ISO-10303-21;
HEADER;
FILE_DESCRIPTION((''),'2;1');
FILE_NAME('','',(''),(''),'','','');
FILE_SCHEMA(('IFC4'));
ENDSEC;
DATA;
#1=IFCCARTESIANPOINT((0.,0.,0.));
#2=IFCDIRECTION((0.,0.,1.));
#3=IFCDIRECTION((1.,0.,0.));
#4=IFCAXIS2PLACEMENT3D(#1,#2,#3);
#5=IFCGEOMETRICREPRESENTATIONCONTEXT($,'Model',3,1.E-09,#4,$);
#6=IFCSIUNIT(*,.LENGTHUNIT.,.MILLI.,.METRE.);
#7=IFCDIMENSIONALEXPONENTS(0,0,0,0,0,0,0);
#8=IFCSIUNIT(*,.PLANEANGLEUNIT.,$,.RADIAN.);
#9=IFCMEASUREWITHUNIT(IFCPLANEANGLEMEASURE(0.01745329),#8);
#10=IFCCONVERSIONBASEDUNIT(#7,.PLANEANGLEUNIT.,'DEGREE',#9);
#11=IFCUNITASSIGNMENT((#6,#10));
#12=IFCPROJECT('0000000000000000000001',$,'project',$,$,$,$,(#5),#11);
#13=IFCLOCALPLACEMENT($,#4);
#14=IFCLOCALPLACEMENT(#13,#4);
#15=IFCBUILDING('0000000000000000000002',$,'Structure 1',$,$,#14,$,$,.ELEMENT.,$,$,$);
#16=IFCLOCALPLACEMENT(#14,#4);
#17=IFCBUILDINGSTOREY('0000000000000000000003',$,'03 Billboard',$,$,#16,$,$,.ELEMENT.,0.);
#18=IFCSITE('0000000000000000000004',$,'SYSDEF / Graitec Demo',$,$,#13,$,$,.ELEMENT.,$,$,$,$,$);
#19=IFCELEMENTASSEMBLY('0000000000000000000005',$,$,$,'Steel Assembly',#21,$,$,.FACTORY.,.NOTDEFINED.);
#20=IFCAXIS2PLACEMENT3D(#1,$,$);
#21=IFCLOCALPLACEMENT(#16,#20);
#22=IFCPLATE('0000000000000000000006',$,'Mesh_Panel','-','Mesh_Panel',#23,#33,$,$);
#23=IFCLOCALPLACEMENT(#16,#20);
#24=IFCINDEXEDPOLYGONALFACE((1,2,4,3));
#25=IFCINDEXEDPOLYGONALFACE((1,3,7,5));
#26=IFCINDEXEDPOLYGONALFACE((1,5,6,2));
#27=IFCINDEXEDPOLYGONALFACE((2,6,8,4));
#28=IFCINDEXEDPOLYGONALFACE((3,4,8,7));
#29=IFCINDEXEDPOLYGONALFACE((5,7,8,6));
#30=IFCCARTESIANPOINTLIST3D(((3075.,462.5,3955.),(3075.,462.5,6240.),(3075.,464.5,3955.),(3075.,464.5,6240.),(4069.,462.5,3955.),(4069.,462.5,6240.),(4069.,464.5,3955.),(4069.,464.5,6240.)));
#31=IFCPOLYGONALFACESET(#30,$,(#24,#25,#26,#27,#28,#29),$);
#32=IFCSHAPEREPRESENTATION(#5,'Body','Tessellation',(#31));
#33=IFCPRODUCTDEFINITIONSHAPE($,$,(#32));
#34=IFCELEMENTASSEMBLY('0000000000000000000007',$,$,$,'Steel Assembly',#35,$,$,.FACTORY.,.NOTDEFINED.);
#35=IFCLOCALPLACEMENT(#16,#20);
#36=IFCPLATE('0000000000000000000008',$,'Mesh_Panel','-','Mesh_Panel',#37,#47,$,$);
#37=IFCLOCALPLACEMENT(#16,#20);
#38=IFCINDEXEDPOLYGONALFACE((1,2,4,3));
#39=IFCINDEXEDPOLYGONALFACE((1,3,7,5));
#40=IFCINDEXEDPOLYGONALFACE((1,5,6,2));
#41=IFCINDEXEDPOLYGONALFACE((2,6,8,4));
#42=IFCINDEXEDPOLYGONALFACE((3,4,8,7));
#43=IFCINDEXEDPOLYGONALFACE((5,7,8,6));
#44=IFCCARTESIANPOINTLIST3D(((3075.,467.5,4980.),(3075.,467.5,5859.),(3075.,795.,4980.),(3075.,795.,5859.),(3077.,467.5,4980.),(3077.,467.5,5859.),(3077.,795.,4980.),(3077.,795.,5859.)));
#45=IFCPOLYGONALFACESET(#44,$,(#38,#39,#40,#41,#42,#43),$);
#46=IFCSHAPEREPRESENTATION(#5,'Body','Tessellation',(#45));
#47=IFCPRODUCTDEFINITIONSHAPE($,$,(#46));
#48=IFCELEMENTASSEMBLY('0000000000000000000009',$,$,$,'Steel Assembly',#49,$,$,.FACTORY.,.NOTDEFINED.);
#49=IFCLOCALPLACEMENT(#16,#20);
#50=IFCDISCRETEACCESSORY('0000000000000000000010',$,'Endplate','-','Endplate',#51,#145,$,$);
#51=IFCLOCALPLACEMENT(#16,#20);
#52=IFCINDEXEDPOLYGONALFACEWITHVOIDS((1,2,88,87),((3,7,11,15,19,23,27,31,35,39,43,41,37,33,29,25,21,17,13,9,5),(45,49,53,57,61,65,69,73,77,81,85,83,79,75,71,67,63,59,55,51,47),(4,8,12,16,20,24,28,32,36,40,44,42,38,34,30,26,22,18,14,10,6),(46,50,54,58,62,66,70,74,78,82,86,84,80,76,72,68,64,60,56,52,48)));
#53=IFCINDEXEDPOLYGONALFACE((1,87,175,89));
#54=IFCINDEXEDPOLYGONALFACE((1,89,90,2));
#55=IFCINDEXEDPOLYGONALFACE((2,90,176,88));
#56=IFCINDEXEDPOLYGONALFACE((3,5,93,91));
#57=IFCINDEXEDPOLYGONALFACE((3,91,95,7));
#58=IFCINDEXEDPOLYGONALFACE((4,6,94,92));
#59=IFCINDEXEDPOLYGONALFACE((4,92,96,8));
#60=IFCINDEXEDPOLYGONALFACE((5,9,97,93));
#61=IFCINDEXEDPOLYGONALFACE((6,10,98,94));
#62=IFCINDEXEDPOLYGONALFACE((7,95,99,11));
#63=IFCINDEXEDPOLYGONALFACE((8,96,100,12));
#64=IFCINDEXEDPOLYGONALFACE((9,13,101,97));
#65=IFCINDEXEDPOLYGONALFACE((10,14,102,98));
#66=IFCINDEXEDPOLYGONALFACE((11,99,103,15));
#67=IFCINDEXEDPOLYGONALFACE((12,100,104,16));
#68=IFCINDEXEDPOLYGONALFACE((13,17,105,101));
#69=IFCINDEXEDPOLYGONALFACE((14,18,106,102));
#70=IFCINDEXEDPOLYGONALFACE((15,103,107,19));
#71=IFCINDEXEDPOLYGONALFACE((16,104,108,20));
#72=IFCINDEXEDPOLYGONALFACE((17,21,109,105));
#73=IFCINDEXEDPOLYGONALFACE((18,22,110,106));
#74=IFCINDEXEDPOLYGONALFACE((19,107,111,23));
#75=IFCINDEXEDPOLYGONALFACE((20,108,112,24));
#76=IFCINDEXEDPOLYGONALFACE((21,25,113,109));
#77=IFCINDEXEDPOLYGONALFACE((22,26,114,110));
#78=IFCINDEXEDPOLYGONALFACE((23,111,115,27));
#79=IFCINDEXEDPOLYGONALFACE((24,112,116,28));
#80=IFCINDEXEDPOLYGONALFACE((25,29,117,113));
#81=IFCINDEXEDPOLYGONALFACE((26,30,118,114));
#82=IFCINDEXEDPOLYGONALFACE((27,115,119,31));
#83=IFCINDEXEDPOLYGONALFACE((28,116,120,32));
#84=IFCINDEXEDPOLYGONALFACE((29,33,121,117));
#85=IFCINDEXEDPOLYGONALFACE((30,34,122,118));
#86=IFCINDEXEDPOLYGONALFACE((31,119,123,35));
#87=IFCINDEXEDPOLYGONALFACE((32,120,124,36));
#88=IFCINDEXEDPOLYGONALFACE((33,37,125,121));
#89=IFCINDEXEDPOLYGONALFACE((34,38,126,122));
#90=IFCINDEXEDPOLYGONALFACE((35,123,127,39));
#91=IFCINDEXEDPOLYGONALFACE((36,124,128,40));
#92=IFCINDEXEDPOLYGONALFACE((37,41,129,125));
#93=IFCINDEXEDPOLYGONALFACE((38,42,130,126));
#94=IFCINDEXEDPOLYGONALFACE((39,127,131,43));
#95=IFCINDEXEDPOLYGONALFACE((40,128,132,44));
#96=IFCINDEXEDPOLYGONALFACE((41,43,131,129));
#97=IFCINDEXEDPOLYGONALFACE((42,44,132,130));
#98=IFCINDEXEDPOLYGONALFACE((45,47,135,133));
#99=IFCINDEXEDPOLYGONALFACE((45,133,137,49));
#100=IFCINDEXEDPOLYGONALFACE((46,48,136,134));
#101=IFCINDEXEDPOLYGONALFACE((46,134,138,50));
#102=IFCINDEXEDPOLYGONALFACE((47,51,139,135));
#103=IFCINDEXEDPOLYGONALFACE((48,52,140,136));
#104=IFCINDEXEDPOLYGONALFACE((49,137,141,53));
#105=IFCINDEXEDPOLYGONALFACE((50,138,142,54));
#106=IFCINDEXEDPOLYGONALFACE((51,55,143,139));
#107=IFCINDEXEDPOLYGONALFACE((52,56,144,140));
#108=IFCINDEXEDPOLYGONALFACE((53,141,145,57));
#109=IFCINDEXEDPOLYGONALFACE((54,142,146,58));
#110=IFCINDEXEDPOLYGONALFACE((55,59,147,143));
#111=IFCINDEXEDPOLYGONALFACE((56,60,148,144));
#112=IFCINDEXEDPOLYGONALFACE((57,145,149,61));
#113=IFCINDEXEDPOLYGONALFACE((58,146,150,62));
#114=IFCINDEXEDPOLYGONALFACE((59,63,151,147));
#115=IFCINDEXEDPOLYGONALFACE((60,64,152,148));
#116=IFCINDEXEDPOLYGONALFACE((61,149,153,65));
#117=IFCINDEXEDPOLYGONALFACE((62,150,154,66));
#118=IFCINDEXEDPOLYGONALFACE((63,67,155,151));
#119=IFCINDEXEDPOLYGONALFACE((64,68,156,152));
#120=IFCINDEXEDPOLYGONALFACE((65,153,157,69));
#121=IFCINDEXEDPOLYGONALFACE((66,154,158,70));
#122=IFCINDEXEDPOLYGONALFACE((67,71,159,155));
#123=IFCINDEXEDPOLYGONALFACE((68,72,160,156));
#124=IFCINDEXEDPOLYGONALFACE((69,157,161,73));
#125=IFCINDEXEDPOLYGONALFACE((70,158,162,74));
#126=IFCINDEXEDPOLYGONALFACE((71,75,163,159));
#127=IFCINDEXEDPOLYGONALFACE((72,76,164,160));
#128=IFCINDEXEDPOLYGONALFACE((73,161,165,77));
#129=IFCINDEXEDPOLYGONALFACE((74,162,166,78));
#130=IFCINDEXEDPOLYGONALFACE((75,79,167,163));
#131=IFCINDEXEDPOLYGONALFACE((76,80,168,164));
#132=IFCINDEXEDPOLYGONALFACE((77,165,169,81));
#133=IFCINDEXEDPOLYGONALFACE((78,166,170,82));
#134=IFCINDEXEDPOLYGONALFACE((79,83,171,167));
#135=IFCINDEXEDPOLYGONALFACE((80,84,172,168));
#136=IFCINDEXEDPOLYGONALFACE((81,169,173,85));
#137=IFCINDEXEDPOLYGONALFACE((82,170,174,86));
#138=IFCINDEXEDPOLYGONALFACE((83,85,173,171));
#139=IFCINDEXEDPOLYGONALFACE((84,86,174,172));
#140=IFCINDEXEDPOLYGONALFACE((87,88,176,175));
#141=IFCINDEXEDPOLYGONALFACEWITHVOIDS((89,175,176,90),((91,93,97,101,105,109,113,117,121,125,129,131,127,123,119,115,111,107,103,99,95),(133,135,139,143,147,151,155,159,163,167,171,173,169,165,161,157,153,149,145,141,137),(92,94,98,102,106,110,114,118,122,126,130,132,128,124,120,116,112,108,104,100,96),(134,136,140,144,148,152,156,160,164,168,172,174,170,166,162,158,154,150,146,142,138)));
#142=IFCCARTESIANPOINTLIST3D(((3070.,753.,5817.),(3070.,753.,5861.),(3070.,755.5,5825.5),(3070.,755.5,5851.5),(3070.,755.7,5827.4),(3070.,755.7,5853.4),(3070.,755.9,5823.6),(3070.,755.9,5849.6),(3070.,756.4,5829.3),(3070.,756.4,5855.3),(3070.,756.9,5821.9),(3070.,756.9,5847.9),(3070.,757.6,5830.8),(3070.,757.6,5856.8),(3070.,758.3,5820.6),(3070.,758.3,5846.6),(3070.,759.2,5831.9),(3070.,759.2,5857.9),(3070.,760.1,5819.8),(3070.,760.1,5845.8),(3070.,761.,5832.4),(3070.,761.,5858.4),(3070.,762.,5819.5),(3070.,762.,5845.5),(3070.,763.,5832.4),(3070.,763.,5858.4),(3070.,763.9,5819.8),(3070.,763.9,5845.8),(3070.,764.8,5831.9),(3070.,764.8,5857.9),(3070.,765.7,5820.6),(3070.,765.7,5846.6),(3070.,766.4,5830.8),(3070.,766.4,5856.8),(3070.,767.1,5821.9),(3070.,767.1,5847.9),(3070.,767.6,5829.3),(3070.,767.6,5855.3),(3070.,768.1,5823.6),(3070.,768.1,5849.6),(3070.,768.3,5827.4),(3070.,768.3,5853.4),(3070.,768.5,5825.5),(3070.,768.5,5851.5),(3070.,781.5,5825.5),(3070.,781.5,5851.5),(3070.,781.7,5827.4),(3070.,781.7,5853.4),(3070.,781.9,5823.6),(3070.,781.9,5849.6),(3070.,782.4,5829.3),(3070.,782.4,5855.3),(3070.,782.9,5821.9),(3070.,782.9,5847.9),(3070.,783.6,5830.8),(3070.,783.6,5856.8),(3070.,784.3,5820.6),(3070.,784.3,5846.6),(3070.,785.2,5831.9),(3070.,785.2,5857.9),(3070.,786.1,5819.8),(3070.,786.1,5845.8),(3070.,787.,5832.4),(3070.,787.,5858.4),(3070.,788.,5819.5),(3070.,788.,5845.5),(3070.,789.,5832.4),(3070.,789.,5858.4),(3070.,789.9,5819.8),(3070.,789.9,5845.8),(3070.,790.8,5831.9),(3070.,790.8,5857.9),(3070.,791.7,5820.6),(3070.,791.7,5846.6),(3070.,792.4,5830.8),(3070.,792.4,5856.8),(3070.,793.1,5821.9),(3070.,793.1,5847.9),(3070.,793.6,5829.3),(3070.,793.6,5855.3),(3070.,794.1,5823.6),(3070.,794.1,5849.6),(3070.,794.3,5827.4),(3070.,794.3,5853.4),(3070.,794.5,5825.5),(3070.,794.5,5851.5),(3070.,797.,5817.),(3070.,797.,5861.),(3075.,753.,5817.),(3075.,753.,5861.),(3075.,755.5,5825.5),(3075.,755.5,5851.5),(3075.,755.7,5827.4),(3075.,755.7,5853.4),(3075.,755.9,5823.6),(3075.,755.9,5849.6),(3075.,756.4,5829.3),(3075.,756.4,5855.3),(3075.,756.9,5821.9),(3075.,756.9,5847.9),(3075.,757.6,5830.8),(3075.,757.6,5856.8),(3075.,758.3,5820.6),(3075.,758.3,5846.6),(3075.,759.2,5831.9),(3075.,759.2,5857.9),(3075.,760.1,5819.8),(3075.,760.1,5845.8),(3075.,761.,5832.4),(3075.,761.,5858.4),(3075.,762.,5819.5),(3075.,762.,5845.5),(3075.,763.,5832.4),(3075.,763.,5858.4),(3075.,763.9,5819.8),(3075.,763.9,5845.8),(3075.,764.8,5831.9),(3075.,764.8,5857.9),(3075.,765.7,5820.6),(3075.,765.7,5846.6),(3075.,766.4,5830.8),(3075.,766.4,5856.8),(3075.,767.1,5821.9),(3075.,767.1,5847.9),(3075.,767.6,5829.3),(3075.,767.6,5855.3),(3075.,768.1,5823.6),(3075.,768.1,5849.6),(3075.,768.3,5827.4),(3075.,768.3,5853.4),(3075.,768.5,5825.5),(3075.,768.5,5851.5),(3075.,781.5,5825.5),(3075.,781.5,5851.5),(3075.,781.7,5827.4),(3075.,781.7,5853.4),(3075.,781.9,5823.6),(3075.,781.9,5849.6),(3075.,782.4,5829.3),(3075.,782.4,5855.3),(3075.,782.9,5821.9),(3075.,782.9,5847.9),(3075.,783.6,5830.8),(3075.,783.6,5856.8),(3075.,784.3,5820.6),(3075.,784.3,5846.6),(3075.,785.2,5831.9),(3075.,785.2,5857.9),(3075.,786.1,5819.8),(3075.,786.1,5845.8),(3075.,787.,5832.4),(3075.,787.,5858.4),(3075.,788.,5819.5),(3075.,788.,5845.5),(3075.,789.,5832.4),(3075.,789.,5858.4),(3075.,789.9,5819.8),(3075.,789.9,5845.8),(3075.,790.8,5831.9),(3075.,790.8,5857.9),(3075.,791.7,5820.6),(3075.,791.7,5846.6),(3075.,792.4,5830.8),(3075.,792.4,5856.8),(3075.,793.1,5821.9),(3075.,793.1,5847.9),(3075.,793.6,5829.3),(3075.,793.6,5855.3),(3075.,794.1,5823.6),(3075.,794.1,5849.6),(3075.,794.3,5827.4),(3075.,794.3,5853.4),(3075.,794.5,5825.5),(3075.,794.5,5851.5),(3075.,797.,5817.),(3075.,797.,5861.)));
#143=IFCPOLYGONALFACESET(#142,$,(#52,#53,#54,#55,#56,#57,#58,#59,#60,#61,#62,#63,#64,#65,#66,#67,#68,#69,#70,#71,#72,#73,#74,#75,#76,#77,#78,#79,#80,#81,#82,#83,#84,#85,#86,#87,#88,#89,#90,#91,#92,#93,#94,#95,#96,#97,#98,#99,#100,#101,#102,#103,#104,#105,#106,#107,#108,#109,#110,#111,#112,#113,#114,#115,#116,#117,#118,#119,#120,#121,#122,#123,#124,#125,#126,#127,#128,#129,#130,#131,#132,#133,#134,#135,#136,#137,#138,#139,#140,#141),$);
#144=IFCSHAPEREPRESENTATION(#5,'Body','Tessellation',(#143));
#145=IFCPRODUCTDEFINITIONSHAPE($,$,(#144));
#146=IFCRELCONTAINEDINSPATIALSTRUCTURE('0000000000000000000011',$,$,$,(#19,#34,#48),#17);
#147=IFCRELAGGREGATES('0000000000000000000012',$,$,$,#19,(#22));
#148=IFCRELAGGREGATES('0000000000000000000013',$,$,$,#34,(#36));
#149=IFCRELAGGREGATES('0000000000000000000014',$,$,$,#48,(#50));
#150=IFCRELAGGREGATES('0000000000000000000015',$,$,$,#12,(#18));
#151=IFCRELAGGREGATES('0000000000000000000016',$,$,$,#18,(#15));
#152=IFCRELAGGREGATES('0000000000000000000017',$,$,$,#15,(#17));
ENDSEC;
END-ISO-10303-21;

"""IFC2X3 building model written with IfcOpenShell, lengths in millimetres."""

from ifc_helpers import new_model, entity, si_unit, converted_unit, frame, frame_2d, origin, origin_with_axes, place, context, project, spatial, polyline, circle, outline, extrude, element, aggregate, save


model = new_model("IFC2X3")

# Units and contexts
model_context = context("Model", 3, precision=1e-09, world=origin_with_axes())
ifc_project = project(units=[si_unit("LENGTHUNIT", "METRE", prefix="MILLI"), converted_unit("PLANEANGLEUNIT", "DEGREE", entity("IfcPlaneAngleMeasure", 0.01745329), si_unit("PLANEANGLEUNIT", "RADIAN"), dimensions=[0, 0, 0, 0, 0, 0, 0])], contexts=[model_context])

# Site, building, storey
site_placement = place(None, origin_with_axes())
site = spatial("IfcSite", under=ifc_project, at=site_placement, Name="SYSDEF / Graitec Demo", CompositionType="ELEMENT")
building_placement = place(site_placement, origin_with_axes())
building = spatial("IfcBuilding", under=site, at=building_placement, Name="Structure 1", CompositionType="ELEMENT")
storey_placement = place(building_placement, origin_with_axes())
storey = spatial("IfcBuildingStorey", under=building, at=storey_placement, Name="03 Billboard", CompositionType="ELEMENT", Elevation=0.0)

# Element assemblies, plates
assembly_1_placement = place(None, frame((3572.0, 464.5, 5097.5), z_axis=(0.0, -1.0, 0.0), x_axis=(-1.0, 0.0, 0.0)))
assembly_1 = element("IfcElementAssembly", 1, at=assembly_1_placement, inside=storey, ObjectType="Steel Assembly", AssemblyPlace="FACTORY", PredefinedType="NOTDEFINED")
plate_1_placement = place(assembly_1_placement, origin_with_axes())
plate_1 = element("IfcPlate", 2, at=plate_1_placement, Name="Mesh_Panel", Description="-", ObjectType="Mesh_Panel", context=model_context, shape_type="SweptSolid", body=[
    extrude(outline(polyline([(-497.0, -1142.5), (497.0, -1142.5), (497.0, 1142.5), (-497.0, 1142.5), (-497.0, -1142.5)])), origin_with_axes(), (0.0, 0.0, 1.0), 2.0),
])
aggregate(assembly_1, [plate_1])
assembly_2_placement = place(None, frame((3077.0, 631.3, 5419.5), z_axis=(-1.0, 0.0, 0.0), x_axis=(0.0, 1.0, 0.0)))
assembly_2 = element("IfcElementAssembly", 3, at=assembly_2_placement, inside=storey, ObjectType="Steel Assembly", AssemblyPlace="FACTORY", PredefinedType="NOTDEFINED")
plate_2_placement = place(assembly_2_placement, origin_with_axes())
plate_2 = element("IfcPlate", 4, at=plate_2_placement, Name="Mesh_Panel", Description="-", ObjectType="Mesh_Panel", context=model_context, shape_type="SweptSolid", body=[
    extrude(outline(polyline([(-163.7, -439.5), (163.7, -439.5), (163.7, 439.5), (-163.7, 439.5), (-163.7, -439.5)])), origin_with_axes(), (0.0, 0.0, 1.0), 2.0),
])
aggregate(assembly_2, [plate_2])

# Element assembly, discrete accessory, openings
assembly_3_placement = place(None, frame((-4239.1, -387.5, 4000.0), z_axis=(-1.0, 0.0, 0.0), x_axis=(0.0, 0.0, 1.0)))
assembly_3 = element("IfcElementAssembly", 5, at=assembly_3_placement, inside=storey, ObjectType="Steel Assembly", AssemblyPlace="FACTORY", PredefinedType="NOTDEFINED")
discrete_accessory_1_placement = place(assembly_3_placement, frame((1861.0, 1184.5, -7309.1), z_axis=(0.0, 0.0, -1.0), x_axis=(0.0, -1.0, 0.0)))
discrete_accessory_1 = element("IfcDiscreteAccessory", 6, at=discrete_accessory_1_placement, Name="Endplate", Description="-", ObjectType="Endplate", context=model_context, shape_type="SweptSolid", body=[
    extrude(outline(polyline([(0.0, 0.0), (44.0, 0.0), (44.0, 44.0), (0.0, 44.0), (0.0, 0.0)])), origin_with_axes(), (0.0, 0.0, 1.0), 5.0),
])
opening_1_placement = place(discrete_accessory_1_placement, frame((22.0, 22.0, 5.5), z_axis=(0.0, 0.0, -1.0), x_axis=(0.0, 1.0, 0.0)))
element("IfcOpeningElement", 7, at=opening_1_placement, cuts=discrete_accessory_1, ObjectType="Opening", context=model_context, shape_type="SweptSolid", body=[
    extrude(circle(Radius=6.5, at=frame_2d((13.0, 13.0), x_axis=(1.0, 0.0))), origin(), (0.0, 0.0, 1.0), 6.0),
])
opening_2_placement = place(discrete_accessory_1_placement, frame((22.0, 22.0, 5.5), z_axis=(0.0, 0.0, -1.0), x_axis=(0.0, 1.0, 0.0)))
element("IfcOpeningElement", 8, at=opening_2_placement, cuts=discrete_accessory_1, ObjectType="Opening", context=model_context, shape_type="SweptSolid", body=[
    extrude(circle(Radius=6.5, at=frame_2d((-13.0, 13.0), x_axis=(1.0, 0.0))), origin(), (0.0, 0.0, 1.0), 6.0),
])
opening_3_placement = place(discrete_accessory_1_placement, frame((22.0, 22.0, 5.5), z_axis=(0.0, 0.0, -1.0), x_axis=(0.0, 1.0, 0.0)))
element("IfcOpeningElement", 9, at=opening_3_placement, cuts=discrete_accessory_1, ObjectType="Opening", context=model_context, shape_type="SweptSolid", body=[
    extrude(circle(Radius=6.5, at=frame_2d((13.0, -13.0), x_axis=(1.0, 0.0))), origin(), (0.0, 0.0, 1.0), 6.0),
])
opening_4_placement = place(discrete_accessory_1_placement, frame((22.0, 22.0, 5.5), z_axis=(0.0, 0.0, -1.0), x_axis=(0.0, 1.0, 0.0)))
element("IfcOpeningElement", 10, at=opening_4_placement, cuts=discrete_accessory_1, ObjectType="Opening", context=model_context, shape_type="SweptSolid", body=[
    extrude(circle(Radius=6.5, at=frame_2d((-13.0, -13.0), x_axis=(1.0, 0.0))), origin(), (0.0, 0.0, 1.0), 6.0),
])
aggregate(assembly_3, [discrete_accessory_1])

save(model, "model.ifc")
